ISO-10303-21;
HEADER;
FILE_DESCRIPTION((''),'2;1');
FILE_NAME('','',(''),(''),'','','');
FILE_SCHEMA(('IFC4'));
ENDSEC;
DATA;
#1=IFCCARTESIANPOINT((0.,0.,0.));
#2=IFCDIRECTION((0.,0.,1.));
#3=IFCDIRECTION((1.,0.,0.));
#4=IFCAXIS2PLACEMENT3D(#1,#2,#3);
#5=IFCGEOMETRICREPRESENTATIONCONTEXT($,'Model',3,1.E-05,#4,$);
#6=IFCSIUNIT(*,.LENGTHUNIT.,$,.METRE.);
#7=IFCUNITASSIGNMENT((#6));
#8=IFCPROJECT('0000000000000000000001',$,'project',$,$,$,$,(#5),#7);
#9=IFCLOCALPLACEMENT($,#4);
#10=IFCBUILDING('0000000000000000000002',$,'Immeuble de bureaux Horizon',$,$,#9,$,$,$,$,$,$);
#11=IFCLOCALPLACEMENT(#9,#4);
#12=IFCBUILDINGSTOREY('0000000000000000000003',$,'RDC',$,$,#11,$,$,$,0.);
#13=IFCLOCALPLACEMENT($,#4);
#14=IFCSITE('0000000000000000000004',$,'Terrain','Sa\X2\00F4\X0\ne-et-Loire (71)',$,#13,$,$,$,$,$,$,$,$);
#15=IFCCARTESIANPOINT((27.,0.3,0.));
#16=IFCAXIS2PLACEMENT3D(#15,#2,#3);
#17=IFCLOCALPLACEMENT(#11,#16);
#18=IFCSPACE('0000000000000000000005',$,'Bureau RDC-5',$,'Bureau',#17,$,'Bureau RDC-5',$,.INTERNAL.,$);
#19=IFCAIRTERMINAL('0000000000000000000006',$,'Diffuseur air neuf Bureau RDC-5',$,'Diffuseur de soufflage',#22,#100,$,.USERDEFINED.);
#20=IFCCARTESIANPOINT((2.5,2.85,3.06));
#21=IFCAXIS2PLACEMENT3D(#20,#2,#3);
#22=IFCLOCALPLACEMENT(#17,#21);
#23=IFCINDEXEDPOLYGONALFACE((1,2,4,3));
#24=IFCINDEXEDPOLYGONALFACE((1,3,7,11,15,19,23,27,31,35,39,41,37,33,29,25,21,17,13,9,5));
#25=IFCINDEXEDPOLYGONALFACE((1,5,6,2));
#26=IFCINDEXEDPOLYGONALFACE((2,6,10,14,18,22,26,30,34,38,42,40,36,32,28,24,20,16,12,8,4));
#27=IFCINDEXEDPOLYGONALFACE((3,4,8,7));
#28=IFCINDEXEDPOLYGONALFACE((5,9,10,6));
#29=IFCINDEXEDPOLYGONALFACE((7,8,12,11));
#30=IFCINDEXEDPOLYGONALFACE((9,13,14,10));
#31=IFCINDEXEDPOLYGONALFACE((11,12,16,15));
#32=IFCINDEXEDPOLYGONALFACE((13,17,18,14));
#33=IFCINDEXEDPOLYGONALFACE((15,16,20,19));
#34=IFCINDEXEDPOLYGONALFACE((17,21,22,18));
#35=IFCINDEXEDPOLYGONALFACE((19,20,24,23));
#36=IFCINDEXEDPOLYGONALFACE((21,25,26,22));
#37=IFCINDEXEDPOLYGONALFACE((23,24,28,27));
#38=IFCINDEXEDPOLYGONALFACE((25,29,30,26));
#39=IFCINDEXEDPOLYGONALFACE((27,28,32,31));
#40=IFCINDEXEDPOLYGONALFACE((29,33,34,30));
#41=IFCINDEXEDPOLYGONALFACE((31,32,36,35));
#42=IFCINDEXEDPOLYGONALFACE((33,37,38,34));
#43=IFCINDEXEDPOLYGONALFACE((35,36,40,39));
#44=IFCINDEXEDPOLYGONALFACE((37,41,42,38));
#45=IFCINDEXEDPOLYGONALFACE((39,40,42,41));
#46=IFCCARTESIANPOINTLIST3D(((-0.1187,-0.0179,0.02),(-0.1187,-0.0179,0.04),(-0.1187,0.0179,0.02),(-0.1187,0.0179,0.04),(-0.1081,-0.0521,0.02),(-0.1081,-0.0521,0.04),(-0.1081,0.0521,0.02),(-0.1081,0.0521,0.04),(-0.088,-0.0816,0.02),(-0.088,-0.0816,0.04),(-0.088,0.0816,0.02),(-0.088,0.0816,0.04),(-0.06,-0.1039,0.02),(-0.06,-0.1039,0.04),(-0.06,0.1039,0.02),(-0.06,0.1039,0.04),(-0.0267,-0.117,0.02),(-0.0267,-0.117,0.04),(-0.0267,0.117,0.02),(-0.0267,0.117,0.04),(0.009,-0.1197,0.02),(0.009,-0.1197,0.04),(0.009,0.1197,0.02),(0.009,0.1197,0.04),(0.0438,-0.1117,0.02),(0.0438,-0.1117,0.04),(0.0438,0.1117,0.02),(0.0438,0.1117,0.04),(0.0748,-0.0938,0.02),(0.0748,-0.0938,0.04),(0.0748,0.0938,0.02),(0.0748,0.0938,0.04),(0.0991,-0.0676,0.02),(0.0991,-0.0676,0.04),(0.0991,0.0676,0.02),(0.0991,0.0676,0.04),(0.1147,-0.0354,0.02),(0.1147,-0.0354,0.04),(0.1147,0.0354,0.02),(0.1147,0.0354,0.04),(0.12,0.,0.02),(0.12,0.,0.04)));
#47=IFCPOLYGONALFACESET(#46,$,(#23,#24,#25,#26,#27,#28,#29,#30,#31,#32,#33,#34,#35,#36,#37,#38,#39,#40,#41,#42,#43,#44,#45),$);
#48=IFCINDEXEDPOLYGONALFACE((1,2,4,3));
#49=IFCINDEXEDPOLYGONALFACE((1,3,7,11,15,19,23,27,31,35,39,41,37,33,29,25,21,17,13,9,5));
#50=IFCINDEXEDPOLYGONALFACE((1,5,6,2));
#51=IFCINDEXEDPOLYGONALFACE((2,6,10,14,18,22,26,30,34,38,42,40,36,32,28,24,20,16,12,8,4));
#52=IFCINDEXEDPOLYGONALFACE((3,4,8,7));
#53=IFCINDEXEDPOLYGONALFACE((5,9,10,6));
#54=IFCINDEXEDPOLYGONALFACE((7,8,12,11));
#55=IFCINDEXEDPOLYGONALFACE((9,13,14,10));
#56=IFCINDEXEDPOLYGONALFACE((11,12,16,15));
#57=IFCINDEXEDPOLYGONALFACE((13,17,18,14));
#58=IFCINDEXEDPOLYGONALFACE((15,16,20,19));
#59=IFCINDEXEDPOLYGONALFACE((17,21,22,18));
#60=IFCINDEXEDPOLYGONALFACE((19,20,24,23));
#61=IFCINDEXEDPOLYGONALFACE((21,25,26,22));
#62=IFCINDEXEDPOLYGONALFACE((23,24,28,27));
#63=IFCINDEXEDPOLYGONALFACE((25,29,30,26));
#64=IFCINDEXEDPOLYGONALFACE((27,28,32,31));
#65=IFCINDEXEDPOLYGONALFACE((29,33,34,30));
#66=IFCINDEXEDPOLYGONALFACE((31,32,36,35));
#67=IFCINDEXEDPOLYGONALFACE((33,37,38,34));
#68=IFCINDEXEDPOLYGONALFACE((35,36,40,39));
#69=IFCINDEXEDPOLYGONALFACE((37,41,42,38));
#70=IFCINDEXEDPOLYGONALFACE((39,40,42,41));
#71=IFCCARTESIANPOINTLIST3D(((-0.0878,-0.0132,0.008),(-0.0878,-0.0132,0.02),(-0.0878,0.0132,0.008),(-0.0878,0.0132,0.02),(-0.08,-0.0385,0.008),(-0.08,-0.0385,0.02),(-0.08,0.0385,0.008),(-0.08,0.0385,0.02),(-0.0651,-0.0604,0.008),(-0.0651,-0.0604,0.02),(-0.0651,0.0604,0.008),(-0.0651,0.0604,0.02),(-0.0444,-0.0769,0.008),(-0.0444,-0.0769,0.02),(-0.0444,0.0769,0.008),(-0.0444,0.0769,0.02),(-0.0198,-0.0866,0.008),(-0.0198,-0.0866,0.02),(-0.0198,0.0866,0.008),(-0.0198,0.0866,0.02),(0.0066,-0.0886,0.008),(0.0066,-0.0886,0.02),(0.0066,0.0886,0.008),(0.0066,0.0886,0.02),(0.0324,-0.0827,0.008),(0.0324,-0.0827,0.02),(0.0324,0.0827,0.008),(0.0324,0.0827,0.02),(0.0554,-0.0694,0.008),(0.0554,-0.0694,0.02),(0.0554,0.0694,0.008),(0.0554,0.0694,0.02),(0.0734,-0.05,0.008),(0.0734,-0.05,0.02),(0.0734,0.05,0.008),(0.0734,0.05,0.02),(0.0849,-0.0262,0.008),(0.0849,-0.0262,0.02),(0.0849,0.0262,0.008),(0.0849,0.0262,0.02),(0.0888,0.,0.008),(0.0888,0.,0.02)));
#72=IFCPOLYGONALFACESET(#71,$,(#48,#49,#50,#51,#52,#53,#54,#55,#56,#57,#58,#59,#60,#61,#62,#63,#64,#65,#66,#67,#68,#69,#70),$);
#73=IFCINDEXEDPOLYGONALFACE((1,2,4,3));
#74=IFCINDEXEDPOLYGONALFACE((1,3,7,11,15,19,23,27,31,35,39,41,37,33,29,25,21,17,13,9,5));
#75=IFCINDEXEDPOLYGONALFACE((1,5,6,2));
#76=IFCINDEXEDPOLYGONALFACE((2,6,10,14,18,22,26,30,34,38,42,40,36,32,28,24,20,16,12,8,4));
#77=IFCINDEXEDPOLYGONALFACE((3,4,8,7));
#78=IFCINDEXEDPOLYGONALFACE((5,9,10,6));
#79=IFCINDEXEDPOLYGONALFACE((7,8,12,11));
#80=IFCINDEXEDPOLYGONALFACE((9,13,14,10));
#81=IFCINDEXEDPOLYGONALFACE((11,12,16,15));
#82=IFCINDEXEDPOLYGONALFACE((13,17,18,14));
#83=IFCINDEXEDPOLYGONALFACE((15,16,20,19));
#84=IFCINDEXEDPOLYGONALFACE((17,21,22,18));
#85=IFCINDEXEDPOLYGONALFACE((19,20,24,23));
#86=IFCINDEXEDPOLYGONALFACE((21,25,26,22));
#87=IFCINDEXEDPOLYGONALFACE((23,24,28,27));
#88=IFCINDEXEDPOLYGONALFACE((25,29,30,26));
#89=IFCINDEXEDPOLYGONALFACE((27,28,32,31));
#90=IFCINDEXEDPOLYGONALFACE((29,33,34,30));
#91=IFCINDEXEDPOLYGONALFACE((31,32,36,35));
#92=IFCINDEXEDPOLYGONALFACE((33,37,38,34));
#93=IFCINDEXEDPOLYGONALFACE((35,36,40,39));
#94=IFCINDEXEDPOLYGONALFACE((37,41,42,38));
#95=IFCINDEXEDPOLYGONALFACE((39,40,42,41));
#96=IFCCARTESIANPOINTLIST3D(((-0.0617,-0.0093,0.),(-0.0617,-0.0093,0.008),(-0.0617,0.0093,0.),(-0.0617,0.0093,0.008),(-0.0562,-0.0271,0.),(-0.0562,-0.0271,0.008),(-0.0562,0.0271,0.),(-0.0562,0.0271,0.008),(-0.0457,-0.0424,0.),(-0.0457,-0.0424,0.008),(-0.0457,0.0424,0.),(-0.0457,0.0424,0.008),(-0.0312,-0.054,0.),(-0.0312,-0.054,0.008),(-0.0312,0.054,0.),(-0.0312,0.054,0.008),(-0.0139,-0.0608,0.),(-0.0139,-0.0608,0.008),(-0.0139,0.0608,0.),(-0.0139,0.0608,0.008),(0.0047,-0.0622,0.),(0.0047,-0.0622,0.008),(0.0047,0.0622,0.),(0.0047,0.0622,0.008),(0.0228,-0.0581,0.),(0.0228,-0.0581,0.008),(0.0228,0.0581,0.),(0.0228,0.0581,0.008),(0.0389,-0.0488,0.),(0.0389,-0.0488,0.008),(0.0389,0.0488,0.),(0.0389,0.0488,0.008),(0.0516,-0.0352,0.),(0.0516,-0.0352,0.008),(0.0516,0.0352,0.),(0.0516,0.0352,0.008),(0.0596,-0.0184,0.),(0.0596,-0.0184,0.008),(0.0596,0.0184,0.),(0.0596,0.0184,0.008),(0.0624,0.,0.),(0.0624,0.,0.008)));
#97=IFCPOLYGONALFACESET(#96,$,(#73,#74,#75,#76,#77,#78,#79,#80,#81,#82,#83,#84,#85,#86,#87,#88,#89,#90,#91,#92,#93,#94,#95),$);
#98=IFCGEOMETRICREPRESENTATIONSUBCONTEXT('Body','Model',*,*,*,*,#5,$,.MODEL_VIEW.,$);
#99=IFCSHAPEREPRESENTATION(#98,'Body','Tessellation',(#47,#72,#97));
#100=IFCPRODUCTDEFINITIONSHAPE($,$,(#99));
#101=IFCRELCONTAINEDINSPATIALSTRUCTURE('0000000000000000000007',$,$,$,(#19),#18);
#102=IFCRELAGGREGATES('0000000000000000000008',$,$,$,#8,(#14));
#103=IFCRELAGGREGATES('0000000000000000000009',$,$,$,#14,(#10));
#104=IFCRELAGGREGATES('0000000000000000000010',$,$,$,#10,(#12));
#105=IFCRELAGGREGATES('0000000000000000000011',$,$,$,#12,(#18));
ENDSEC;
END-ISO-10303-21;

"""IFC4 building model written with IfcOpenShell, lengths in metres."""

from ifc_helpers import new_model, si_unit, frame, origin_with_axes, place, context, subcontext, project, spatial, circle, extrude, element, save


model = new_model("IFC4")

# Units and contexts
model_context = context("Model", 3, precision=1e-05, world=origin_with_axes())
body_context = subcontext(model_context, "Body", "Model", "MODEL_VIEW")
ifc_project = project(units=[si_unit("LENGTHUNIT", "METRE")], contexts=[model_context])

# Site, building, storey
site_placement = place(None, origin_with_axes())
site = spatial("IfcSite", under=ifc_project, at=site_placement, Name="Terrain", Description="Saône-et-Loire (71)")
building_placement = place(None, origin_with_axes())
building = spatial("IfcBuilding", under=site, at=building_placement, Name="Immeuble de bureaux Horizon")
storey_placement = place(building_placement, origin_with_axes())
storey = spatial("IfcBuildingStorey", under=building, at=storey_placement, Name="RDC", Elevation=0.0)

# Shared definitions
space_placement = place(storey_placement, frame((27.0, 0.3, 0.0), z_axis=(0.0, 0.0, 1.0), x_axis=(1.0, 0.0, 0.0)))
space = spatial("IfcSpace", under=storey, at=space_placement, Name="Bureau RDC-5", ObjectType="Bureau", LongName="Bureau RDC-5", PredefinedType="INTERNAL")

# Air terminal
air_terminal_placement = place(space_placement, frame((2.5, 2.85, 3.06), z_axis=(0.0, 0.0, 1.0), x_axis=(1.0, 0.0, 0.0)))
element("IfcAirTerminal", 1, at=air_terminal_placement, inside=space, Name="Diffuseur air neuf Bureau RDC-5", ObjectType="Diffuseur de soufflage", PredefinedType="USERDEFINED", context=body_context, shape_type="SweptSolid", body=[
    extrude(circle(Radius=0.12), frame((0.0, 0.0, 0.02), z_axis=(0.0, 0.0, 1.0), x_axis=(1.0, 0.0, 0.0)), (0.0, 0.0, 1.0), 0.02),
    extrude(circle(Radius=0.0888), frame((0.0, 0.0, 0.008), z_axis=(0.0, 0.0, 1.0), x_axis=(1.0, 0.0, 0.0)), (0.0, 0.0, 1.0), 0.012),
    extrude(circle(Radius=0.0624), origin_with_axes(), (0.0, 0.0, 1.0), 0.008),
])

save(model, "model.ifc")
